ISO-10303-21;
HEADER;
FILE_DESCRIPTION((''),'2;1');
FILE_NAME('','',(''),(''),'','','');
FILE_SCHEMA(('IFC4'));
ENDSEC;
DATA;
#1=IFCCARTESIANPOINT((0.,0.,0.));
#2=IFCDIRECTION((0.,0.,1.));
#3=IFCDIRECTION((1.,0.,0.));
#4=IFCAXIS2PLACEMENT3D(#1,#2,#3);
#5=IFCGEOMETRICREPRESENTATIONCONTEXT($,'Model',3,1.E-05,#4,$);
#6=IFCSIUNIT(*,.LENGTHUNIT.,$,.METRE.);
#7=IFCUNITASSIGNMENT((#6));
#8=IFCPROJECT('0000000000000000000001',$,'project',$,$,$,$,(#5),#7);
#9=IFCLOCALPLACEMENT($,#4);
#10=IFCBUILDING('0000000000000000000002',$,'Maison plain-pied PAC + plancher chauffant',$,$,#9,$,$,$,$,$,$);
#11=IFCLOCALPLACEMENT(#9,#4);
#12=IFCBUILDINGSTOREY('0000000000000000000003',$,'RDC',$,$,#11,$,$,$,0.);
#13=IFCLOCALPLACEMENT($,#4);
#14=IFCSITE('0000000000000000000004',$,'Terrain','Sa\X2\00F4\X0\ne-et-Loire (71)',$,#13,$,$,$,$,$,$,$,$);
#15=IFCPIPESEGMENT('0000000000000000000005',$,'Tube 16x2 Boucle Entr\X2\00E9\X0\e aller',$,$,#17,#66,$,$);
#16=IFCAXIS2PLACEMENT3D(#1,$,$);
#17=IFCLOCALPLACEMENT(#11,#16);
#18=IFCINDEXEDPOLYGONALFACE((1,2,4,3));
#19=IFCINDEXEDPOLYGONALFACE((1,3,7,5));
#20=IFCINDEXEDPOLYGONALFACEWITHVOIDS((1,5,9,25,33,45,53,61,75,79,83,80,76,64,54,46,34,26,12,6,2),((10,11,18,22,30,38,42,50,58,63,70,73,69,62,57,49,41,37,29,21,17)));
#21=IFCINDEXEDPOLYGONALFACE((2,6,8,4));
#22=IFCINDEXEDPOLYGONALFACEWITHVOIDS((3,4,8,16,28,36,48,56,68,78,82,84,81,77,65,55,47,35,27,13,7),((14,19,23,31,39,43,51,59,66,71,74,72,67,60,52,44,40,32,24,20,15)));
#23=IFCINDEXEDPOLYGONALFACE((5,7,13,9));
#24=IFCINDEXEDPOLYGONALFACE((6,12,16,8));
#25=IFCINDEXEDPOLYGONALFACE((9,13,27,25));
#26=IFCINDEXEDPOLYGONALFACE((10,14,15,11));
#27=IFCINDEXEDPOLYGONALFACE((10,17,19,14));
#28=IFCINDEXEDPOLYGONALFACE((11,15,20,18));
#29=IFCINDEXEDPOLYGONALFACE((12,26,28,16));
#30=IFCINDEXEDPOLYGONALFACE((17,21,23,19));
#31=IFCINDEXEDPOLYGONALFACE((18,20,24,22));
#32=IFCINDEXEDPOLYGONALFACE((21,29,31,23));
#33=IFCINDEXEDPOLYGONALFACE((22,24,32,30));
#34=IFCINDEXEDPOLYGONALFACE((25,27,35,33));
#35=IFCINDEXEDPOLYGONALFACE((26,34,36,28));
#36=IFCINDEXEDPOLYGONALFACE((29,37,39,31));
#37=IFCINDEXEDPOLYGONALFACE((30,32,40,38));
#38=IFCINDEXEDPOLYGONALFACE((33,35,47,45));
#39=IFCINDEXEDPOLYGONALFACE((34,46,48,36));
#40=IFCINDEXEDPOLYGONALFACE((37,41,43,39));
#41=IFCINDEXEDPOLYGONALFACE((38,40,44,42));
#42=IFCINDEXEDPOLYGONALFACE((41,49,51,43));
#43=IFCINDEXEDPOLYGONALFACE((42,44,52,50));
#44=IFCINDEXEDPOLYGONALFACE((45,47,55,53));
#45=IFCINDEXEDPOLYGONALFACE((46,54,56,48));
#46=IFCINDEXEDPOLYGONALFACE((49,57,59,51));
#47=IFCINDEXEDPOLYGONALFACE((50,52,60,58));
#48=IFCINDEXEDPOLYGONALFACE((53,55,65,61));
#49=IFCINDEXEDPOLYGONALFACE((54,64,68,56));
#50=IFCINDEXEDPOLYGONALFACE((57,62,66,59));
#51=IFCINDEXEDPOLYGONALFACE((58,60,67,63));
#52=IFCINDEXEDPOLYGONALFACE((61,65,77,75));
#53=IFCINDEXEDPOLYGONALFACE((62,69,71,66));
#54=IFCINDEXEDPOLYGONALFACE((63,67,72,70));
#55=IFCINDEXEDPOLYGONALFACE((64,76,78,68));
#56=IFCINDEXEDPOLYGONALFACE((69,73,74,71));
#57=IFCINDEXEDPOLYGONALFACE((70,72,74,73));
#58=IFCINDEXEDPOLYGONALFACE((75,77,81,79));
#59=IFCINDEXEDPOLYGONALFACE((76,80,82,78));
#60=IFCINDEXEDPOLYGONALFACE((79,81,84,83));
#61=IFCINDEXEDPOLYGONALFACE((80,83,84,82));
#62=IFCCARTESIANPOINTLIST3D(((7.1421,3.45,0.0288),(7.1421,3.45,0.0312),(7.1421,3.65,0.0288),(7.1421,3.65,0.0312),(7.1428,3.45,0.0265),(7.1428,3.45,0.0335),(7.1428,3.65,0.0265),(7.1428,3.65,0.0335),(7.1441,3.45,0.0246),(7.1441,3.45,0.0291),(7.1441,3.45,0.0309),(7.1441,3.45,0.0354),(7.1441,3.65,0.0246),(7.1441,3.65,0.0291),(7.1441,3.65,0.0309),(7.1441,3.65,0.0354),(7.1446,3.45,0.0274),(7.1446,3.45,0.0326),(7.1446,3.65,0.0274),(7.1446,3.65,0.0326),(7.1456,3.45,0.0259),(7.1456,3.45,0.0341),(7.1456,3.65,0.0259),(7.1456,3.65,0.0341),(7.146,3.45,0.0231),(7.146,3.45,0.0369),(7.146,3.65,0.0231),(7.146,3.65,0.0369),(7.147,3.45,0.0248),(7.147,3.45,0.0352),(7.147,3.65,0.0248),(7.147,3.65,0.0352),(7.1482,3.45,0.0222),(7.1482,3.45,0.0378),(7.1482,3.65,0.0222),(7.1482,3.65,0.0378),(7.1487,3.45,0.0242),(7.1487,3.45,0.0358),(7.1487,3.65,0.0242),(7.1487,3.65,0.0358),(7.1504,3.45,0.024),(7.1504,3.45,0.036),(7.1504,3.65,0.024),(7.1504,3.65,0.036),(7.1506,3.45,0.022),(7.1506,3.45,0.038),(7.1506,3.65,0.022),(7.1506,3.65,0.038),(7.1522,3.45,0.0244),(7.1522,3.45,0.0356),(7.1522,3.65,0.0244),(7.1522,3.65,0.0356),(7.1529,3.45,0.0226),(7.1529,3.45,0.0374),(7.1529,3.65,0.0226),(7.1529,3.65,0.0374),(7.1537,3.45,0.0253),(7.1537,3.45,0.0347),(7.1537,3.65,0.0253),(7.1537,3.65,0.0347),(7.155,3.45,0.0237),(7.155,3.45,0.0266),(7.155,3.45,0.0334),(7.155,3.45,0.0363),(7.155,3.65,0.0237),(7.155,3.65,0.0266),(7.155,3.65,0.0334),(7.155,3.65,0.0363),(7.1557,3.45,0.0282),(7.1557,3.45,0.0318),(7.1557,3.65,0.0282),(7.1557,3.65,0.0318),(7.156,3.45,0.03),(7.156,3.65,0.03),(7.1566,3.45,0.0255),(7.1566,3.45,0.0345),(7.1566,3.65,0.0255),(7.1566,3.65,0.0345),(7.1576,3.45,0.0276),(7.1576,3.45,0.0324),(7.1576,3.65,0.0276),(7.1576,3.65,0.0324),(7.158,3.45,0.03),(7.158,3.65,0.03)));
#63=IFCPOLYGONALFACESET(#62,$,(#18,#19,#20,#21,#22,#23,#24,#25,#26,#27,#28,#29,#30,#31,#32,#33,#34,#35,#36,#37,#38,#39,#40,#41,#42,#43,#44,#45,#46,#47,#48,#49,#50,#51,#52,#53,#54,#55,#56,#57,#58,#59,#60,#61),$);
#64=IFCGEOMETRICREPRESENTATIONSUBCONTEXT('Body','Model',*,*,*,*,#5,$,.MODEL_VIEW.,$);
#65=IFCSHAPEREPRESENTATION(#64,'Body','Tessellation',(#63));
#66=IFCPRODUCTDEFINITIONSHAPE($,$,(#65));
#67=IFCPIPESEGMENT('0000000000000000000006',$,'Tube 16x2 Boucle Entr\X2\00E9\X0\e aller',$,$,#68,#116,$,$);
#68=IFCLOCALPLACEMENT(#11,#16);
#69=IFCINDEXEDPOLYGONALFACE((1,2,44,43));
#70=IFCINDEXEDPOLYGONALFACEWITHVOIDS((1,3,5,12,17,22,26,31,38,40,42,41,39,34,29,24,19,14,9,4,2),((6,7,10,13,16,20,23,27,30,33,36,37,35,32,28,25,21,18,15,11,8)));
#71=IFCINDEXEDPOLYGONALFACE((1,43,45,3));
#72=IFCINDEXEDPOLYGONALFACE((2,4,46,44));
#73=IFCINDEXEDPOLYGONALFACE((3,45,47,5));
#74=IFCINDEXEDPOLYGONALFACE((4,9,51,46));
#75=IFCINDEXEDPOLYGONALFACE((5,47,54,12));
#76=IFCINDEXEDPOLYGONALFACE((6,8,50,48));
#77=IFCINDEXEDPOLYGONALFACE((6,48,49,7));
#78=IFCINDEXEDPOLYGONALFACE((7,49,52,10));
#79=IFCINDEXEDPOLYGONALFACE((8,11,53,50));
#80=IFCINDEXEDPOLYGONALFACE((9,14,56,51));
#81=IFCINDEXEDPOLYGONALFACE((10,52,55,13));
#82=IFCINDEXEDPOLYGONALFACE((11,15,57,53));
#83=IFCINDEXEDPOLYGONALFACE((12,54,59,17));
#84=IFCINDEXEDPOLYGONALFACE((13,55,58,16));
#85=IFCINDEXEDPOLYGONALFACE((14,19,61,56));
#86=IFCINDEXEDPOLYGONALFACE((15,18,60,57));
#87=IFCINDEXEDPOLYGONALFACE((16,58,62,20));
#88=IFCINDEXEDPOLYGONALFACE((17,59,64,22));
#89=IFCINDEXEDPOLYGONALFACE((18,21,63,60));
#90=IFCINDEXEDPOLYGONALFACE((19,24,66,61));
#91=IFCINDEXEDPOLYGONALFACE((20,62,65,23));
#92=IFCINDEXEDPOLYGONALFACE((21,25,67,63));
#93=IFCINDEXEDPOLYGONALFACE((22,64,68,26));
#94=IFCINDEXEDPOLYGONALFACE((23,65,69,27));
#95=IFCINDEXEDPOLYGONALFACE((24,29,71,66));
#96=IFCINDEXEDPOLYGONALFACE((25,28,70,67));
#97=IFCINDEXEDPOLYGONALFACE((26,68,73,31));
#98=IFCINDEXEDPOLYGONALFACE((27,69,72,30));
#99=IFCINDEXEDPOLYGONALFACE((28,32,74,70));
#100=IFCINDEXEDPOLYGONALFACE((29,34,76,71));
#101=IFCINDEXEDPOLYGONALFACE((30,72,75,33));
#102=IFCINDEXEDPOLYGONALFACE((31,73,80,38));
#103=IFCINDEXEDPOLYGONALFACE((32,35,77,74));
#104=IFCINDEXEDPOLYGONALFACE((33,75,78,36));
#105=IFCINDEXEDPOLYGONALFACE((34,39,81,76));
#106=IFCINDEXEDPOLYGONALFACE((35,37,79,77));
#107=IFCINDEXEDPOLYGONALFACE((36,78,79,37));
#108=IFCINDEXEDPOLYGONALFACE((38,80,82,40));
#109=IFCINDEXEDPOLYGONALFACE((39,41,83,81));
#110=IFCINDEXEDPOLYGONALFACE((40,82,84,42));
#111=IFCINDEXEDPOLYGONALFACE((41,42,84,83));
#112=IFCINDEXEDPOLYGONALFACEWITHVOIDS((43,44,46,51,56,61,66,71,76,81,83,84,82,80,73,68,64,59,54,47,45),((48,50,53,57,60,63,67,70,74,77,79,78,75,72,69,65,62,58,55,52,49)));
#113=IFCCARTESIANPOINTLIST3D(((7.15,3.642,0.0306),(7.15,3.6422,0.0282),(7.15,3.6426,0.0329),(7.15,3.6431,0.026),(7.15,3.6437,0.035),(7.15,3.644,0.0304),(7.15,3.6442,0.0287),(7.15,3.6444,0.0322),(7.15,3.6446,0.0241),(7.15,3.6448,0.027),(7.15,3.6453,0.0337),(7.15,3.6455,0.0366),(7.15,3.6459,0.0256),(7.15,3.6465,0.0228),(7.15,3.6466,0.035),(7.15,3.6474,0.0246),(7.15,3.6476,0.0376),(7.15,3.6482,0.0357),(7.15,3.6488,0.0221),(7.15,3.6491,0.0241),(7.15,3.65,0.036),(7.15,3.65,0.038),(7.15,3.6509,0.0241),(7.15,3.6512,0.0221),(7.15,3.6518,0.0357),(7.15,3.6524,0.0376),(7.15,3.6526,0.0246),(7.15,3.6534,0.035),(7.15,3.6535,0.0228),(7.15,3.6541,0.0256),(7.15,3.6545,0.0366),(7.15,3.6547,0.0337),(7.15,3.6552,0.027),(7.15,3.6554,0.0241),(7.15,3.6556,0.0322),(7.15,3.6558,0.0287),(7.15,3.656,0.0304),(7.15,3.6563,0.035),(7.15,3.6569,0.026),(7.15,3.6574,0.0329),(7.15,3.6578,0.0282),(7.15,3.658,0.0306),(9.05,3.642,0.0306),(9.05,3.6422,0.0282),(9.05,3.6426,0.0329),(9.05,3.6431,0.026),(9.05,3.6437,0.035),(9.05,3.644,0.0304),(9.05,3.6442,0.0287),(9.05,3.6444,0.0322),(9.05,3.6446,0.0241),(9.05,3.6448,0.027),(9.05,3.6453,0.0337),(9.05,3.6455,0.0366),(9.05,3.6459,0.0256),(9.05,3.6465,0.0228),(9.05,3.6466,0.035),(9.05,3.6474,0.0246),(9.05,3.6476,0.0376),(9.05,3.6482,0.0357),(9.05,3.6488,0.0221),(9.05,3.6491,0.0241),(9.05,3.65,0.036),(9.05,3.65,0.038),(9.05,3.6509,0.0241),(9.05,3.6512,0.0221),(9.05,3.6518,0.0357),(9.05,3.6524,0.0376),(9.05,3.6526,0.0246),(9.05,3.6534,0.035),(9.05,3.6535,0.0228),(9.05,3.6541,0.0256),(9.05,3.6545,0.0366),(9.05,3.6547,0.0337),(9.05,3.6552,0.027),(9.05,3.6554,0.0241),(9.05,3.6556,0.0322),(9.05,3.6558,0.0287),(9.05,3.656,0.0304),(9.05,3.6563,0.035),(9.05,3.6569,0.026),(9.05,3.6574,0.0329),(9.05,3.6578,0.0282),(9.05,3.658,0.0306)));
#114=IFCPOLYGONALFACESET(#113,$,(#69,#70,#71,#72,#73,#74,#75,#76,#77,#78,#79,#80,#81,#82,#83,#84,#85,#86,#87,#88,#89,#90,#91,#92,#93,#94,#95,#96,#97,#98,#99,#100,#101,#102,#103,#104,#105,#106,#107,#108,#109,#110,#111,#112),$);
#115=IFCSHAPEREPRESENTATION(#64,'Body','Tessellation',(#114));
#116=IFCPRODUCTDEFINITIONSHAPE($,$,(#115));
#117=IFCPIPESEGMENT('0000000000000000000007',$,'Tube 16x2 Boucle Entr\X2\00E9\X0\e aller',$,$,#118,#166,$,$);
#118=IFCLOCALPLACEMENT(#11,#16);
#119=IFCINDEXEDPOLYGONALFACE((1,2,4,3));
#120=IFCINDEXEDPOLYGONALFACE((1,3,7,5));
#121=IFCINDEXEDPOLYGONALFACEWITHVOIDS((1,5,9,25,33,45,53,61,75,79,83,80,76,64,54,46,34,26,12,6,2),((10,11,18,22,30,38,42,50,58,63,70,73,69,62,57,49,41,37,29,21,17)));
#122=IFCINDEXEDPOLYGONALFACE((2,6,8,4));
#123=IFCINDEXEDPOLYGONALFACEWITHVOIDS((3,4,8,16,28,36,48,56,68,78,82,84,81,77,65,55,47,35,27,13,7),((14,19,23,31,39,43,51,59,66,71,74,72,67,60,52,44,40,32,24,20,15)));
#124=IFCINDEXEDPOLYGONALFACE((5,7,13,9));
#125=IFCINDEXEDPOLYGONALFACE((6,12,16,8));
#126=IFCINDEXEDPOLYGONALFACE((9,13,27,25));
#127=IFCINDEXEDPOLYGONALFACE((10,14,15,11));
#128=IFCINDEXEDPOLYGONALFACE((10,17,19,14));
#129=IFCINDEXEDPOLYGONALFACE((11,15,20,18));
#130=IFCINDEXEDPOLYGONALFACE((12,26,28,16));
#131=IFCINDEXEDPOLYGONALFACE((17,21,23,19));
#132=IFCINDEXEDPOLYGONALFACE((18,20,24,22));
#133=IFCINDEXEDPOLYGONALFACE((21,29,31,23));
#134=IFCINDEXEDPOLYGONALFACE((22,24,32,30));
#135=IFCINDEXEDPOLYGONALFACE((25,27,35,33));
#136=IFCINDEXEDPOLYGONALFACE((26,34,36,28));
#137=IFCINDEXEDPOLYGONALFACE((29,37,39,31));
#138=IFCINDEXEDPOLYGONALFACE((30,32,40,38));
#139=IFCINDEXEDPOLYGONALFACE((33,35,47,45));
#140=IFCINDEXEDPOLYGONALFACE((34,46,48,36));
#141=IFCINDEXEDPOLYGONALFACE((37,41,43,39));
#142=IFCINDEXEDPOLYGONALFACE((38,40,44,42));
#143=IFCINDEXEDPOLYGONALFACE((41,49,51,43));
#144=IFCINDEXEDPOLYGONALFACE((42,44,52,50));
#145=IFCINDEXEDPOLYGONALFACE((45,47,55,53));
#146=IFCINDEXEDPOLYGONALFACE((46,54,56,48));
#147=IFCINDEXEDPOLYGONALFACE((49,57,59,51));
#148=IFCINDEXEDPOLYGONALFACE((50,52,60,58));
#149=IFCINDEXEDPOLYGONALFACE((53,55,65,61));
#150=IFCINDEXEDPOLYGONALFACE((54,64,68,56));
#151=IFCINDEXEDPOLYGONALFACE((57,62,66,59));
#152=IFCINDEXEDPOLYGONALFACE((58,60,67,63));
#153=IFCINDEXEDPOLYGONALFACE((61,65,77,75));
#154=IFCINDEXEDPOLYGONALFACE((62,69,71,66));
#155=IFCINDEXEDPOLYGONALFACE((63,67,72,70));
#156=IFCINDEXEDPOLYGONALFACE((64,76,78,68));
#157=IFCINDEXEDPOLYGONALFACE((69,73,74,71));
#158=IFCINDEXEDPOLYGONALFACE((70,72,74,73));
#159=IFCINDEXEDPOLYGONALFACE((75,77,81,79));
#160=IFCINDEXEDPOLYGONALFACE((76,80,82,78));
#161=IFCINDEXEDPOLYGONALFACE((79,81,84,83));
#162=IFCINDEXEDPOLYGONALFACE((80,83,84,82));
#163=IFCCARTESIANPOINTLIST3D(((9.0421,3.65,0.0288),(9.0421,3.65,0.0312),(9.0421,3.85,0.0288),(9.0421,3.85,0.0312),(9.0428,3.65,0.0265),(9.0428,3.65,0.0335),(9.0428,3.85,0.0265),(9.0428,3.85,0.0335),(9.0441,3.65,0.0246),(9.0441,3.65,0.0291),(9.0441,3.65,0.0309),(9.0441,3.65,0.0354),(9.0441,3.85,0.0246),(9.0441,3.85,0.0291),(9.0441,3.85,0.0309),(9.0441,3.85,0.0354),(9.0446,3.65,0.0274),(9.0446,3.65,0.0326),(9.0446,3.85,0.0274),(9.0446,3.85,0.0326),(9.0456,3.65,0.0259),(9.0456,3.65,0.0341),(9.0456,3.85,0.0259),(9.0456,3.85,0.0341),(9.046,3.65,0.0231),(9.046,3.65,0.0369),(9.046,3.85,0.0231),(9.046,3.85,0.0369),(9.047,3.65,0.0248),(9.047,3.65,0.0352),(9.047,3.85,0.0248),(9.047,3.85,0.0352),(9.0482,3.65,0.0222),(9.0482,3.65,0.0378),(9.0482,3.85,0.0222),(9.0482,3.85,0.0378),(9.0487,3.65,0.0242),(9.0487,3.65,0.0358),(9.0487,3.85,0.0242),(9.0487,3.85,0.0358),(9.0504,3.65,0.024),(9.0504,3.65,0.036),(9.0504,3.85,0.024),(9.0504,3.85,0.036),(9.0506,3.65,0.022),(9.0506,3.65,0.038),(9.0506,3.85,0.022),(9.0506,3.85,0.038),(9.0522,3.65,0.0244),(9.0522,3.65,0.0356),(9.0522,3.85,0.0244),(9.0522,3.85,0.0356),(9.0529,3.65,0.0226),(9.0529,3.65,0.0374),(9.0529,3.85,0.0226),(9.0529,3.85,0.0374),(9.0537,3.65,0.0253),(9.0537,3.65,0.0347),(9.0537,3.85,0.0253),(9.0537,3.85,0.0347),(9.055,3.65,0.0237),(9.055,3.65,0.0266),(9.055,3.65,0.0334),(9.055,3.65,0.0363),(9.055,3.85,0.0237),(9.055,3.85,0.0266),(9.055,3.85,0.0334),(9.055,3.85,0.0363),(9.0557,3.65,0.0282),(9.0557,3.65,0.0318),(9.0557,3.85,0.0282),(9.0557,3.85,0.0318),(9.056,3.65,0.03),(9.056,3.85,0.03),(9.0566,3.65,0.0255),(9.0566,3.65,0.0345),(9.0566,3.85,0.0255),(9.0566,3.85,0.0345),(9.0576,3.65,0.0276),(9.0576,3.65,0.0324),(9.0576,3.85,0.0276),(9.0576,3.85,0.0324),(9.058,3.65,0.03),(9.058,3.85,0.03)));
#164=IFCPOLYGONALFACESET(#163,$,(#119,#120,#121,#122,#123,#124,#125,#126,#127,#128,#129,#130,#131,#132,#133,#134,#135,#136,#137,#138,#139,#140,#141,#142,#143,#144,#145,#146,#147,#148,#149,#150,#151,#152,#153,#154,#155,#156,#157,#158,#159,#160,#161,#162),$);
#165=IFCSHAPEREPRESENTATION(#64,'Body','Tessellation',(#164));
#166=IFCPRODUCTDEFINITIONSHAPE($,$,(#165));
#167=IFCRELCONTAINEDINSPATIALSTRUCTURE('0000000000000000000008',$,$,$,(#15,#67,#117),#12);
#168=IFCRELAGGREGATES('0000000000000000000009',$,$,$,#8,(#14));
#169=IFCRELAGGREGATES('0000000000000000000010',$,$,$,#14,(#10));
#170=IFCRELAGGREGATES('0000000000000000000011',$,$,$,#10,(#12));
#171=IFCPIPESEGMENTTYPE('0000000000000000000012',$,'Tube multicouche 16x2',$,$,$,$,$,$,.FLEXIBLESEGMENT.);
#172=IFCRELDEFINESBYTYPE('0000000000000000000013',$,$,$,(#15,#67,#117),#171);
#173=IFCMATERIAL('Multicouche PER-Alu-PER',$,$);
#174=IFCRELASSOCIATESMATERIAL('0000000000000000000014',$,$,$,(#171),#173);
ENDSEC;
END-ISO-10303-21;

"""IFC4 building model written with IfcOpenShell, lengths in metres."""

from ifc_helpers import new_model, si_unit, frame, origin_with_axes, place, context, subcontext, project, spatial, hollow_circle, extrude, material, type_object, element, save


model = new_model("IFC4")

# Units and contexts
model_context = context("Model", 3, precision=1e-05, world=origin_with_axes())
body_context = subcontext(model_context, "Body", "Model", "MODEL_VIEW")
ifc_project = project(units=[si_unit("LENGTHUNIT", "METRE")], contexts=[model_context])

# Site, building, storey
site_placement = place(None, origin_with_axes())
site = spatial("IfcSite", under=ifc_project, at=site_placement, Name="Terrain", Description="Saône-et-Loire (71)")
building_placement = place(None, origin_with_axes())
building = spatial("IfcBuilding", under=site, at=building_placement, Name="Maison plain-pied PAC + plancher chauffant")
storey_placement = place(building_placement, origin_with_axes())
storey = spatial("IfcBuildingStorey", under=building, at=storey_placement, Name="RDC", Elevation=0.0)

# Pipe segments
ifc_material = material(Name="Multicouche PER-Alu-PER")
pipe_segment_type = type_object("IfcPipeSegmentType", Name="Tube multicouche 16x2", PredefinedType="FLEXIBLESEGMENT", material=ifc_material)
pipe_segment_1_placement = place(storey_placement, frame((7.15, 3.45, 0.03), z_axis=(0.0, 1.0, 0.0), x_axis=(1.0, 0.0, 0.0)))
element("IfcPipeSegment", 1, at=pipe_segment_1_placement, inside=storey, type_object=pipe_segment_type, Name="Tube 16x2 Boucle Entrée aller", context=body_context, shape_type="SweptSolid", body=[
    extrude(hollow_circle(Radius=0.008, WallThickness=0.002), origin_with_axes(), (0.0, 0.0, 1.0), 0.2),
])
pipe_segment_2_placement = place(storey_placement, frame((7.15, 3.65, 0.03), z_axis=(1.0, 0.0, 0.0), x_axis=(0.0, 0.0, 1.0)))
element("IfcPipeSegment", 2, at=pipe_segment_2_placement, inside=storey, type_object=pipe_segment_type, Name="Tube 16x2 Boucle Entrée aller", context=body_context, shape_type="SweptSolid", body=[
    extrude(hollow_circle(Radius=0.008, WallThickness=0.002), origin_with_axes(), (0.0, 0.0, 1.0), 1.9),
])
pipe_segment_3_placement = place(storey_placement, frame((9.05, 3.65, 0.03), z_axis=(0.0, 1.0, 0.0), x_axis=(1.0, 0.0, 0.0)))
element("IfcPipeSegment", 3, at=pipe_segment_3_placement, inside=storey, type_object=pipe_segment_type, Name="Tube 16x2 Boucle Entrée aller", context=body_context, shape_type="SweptSolid", body=[
    extrude(hollow_circle(Radius=0.008, WallThickness=0.002), origin_with_axes(), (0.0, 0.0, 1.0), 0.2),
])

save(model, "model.ifc")
